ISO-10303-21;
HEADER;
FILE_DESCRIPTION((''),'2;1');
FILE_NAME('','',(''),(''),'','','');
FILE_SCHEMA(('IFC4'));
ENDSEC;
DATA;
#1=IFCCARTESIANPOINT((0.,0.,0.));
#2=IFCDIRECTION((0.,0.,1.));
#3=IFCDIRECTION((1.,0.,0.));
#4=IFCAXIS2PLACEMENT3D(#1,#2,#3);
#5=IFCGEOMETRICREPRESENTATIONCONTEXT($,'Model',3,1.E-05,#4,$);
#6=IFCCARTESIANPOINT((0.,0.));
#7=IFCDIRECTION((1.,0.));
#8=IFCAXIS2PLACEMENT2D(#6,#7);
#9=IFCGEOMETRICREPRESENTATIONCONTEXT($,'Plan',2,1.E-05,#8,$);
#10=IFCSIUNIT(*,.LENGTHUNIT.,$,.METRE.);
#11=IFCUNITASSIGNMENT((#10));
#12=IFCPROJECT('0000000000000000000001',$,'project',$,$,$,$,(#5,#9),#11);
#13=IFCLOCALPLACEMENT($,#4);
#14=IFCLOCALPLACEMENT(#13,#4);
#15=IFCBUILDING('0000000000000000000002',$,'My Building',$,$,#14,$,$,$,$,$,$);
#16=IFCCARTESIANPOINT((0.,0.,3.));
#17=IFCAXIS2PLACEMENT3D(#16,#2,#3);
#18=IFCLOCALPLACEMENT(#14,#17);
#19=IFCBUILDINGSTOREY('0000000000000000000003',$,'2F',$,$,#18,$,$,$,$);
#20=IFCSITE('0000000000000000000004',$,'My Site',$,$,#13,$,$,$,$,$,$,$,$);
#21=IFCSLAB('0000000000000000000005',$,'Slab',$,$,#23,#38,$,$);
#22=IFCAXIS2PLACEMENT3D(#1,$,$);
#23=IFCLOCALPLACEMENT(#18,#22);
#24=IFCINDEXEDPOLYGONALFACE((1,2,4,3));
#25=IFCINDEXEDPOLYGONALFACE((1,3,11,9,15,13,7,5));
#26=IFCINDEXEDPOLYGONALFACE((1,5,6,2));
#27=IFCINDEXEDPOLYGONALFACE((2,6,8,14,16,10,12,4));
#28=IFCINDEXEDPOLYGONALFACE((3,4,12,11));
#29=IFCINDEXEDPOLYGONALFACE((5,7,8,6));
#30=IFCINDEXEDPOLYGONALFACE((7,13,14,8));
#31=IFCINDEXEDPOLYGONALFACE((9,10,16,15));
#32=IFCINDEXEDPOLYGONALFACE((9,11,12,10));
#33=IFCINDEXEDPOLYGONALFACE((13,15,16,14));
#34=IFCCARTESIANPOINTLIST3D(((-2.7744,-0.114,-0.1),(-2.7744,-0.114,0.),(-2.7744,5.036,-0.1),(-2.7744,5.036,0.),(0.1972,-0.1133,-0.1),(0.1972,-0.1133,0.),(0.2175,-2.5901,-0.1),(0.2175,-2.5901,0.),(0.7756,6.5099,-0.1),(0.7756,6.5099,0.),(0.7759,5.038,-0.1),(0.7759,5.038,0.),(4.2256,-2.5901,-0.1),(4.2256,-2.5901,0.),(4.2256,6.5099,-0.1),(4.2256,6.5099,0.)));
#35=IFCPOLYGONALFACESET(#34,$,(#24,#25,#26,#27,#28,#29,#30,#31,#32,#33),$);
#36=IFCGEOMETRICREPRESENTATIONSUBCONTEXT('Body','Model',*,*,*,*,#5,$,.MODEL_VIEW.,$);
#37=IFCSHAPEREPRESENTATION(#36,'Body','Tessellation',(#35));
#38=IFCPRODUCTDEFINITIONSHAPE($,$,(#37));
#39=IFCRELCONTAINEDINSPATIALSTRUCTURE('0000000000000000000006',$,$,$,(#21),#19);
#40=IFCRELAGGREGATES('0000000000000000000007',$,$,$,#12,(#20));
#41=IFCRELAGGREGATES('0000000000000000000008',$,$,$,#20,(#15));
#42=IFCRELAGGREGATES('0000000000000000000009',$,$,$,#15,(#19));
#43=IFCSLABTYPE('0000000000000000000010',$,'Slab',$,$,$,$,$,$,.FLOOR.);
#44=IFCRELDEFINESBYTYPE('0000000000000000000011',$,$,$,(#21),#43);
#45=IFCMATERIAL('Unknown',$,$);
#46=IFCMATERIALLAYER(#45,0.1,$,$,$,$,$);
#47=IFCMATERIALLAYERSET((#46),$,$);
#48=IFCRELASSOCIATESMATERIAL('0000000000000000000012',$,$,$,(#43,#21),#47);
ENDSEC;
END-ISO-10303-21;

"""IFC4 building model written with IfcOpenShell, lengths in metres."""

from ifc_helpers import new_model, si_unit, frame, origin_with_axes, origin_2d_with_axis, place, context, subcontext, project, spatial, indexed_curve, outline, extrude, material, layer, layer_set, layer_usage, type_object, element, save


model = new_model("IFC4")

# Units and contexts
model_context = context("Model", 3, precision=1e-05, world=origin_with_axes())
plan_context = context("Plan", 2, precision=1e-05, world=origin_2d_with_axis())
body_context = subcontext(model_context, "Body", "Model", "MODEL_VIEW")
ifc_project = project(units=[si_unit("LENGTHUNIT", "METRE")], contexts=[model_context, plan_context])

# Site, building, storey
site_placement = place(None, origin_with_axes())
site = spatial("IfcSite", under=ifc_project, at=site_placement, Name="My Site")
building_placement = place(site_placement, origin_with_axes())
building = spatial("IfcBuilding", under=site, at=building_placement, Name="My Building")
storey_placement = place(building_placement, frame((0.0, 0.0, 3.0), z_axis=(0.0, 0.0, 1.0), x_axis=(1.0, 0.0, 0.0)))
storey = spatial("IfcBuildingStorey", under=building, at=storey_placement, Name="2F")

# Slab
ifc_material = material(Name="Unknown")
ifc_layer = layer(ifc_material, 0.1)
ifc_layer_set = layer_set([ifc_layer])
ifc_layer_usage = layer_usage(ifc_layer_set, "AXIS3", "POSITIVE", -0.1)
slab_type = type_object("IfcSlabType", Name="Slab", PredefinedType="FLOOR", material=ifc_layer_set)
slab_placement = place(storey_placement, frame((4.2256, -2.5901, 0.0), z_axis=(0.0, 0.0, 1.0), x_axis=(1.0, 0.0, 0.0)))
element("IfcSlab", 1, at=slab_placement, inside=storey, type_object=slab_type, material=ifc_layer_usage, Name="Slab", context=body_context, shape_type="SweptSolid", body=[
    extrude(outline(indexed_curve([(0.0, 0.0), (0.0, 9.1), (-3.45, 9.1), (-3.4497, 7.6281), (-7.0, 7.6261), (-7.0, 2.4761), (-4.0284, 2.4768), (-4.0081, 0.0), (0.0, 0.0)])), frame((0.0, 0.0, -0.1), z_axis=(0.0, 0.0, 1.0), x_axis=(1.0, 0.0, 0.0)), (0.0, 0.0, 1.0), 0.1),
])

save(model, "model.ifc")
